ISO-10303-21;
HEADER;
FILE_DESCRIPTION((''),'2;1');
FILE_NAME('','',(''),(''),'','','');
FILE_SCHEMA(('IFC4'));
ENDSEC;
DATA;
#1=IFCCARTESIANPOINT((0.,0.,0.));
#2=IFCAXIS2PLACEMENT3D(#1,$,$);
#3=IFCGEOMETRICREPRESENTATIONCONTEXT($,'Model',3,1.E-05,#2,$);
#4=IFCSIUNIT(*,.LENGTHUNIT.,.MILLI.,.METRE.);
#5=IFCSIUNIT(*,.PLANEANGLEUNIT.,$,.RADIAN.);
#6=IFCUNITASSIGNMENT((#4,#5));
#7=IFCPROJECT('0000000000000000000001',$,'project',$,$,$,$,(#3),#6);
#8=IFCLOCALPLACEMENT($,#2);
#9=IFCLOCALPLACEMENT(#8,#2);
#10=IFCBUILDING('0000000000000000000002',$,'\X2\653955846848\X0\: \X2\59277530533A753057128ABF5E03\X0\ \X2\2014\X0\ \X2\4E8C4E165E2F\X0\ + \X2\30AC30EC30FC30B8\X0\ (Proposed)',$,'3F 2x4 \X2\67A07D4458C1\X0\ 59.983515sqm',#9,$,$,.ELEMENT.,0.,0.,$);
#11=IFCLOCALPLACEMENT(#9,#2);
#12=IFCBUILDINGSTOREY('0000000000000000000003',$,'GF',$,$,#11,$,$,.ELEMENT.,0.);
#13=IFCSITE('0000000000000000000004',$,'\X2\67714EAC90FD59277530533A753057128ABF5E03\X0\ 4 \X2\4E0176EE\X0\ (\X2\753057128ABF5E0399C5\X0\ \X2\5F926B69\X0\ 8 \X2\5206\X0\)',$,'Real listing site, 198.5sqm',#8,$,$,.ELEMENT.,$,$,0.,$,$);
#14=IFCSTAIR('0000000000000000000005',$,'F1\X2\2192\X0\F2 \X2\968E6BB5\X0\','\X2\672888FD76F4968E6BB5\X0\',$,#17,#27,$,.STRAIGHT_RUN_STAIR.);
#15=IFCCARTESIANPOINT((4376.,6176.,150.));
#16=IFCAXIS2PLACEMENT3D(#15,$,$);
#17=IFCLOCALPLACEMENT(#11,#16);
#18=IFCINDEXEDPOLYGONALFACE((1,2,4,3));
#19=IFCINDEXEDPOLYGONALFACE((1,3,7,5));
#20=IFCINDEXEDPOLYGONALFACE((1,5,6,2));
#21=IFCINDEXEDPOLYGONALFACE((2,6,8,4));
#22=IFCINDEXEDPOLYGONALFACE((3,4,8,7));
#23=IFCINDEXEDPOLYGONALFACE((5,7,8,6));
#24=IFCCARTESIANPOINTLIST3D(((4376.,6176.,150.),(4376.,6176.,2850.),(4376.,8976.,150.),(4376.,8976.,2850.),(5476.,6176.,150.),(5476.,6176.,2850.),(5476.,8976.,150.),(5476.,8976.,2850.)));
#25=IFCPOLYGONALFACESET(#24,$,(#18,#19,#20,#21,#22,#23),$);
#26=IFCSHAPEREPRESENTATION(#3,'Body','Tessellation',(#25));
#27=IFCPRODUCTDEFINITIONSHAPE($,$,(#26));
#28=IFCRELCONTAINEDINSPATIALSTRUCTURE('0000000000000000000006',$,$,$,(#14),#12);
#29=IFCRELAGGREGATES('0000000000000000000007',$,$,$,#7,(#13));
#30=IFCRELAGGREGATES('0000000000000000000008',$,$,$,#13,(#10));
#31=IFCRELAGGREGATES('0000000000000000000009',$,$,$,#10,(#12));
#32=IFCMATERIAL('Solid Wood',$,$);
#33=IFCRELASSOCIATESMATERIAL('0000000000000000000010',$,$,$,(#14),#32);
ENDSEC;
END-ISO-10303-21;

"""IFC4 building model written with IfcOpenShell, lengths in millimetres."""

from ifc_helpers import new_model, si_unit, frame, frame_2d, origin, place, context, project, spatial, rectangle, extrude, material, element, save


model = new_model("IFC4")

# Units and contexts
model_context = context("Model", 3, precision=1e-05, world=origin())
ifc_project = project(units=[si_unit("LENGTHUNIT", "METRE", prefix="MILLI"), si_unit("PLANEANGLEUNIT", "RADIAN")], contexts=[model_context])

# Site, building, storey
site_placement = place(None, origin())
site = spatial("IfcSite", under=ifc_project, at=site_placement, Name="東京都大田区田園調布 4 丁目 (田園調布駅 徒歩 8 分)", ObjectType="Real listing site, 198.5sqm", CompositionType="ELEMENT", RefElevation=0.0)
building_placement = place(site_placement, origin())
building = spatial("IfcBuilding", under=site, at=building_placement, Name="改善案: 大田区田園調布 — 二世帯 + ガレージ (Proposed)", ObjectType="3F 2x4 枠組壁 59.983515sqm", CompositionType="ELEMENT", ElevationOfRefHeight=0.0, ElevationOfTerrain=0.0)
storey_placement = place(building_placement, origin())
storey = spatial("IfcBuildingStorey", under=building, at=storey_placement, Name="GF", CompositionType="ELEMENT", Elevation=0.0)

# Shared definitions
ifc_material_1 = material(Name="Solid Wood")

# Stair
stair_placement = place(storey_placement, frame((4376.0, 6176.0, 150.0)))
element("IfcStair", 1, at=stair_placement, inside=storey, material=ifc_material_1, Name="F1→F2 階段", Description="木製直階段", PredefinedType="STRAIGHT_RUN_STAIR", context=model_context, shape_type="SweptSolid", body=[
    extrude(rectangle(XDim=1100.0, YDim=2800.0, at=frame_2d((550.0, 1400.0))), frame((4376.0, 6176.0, 150.0)), (0.0, 0.0, 1.0), 2700.0),
])

save(model, "model.ifc")
